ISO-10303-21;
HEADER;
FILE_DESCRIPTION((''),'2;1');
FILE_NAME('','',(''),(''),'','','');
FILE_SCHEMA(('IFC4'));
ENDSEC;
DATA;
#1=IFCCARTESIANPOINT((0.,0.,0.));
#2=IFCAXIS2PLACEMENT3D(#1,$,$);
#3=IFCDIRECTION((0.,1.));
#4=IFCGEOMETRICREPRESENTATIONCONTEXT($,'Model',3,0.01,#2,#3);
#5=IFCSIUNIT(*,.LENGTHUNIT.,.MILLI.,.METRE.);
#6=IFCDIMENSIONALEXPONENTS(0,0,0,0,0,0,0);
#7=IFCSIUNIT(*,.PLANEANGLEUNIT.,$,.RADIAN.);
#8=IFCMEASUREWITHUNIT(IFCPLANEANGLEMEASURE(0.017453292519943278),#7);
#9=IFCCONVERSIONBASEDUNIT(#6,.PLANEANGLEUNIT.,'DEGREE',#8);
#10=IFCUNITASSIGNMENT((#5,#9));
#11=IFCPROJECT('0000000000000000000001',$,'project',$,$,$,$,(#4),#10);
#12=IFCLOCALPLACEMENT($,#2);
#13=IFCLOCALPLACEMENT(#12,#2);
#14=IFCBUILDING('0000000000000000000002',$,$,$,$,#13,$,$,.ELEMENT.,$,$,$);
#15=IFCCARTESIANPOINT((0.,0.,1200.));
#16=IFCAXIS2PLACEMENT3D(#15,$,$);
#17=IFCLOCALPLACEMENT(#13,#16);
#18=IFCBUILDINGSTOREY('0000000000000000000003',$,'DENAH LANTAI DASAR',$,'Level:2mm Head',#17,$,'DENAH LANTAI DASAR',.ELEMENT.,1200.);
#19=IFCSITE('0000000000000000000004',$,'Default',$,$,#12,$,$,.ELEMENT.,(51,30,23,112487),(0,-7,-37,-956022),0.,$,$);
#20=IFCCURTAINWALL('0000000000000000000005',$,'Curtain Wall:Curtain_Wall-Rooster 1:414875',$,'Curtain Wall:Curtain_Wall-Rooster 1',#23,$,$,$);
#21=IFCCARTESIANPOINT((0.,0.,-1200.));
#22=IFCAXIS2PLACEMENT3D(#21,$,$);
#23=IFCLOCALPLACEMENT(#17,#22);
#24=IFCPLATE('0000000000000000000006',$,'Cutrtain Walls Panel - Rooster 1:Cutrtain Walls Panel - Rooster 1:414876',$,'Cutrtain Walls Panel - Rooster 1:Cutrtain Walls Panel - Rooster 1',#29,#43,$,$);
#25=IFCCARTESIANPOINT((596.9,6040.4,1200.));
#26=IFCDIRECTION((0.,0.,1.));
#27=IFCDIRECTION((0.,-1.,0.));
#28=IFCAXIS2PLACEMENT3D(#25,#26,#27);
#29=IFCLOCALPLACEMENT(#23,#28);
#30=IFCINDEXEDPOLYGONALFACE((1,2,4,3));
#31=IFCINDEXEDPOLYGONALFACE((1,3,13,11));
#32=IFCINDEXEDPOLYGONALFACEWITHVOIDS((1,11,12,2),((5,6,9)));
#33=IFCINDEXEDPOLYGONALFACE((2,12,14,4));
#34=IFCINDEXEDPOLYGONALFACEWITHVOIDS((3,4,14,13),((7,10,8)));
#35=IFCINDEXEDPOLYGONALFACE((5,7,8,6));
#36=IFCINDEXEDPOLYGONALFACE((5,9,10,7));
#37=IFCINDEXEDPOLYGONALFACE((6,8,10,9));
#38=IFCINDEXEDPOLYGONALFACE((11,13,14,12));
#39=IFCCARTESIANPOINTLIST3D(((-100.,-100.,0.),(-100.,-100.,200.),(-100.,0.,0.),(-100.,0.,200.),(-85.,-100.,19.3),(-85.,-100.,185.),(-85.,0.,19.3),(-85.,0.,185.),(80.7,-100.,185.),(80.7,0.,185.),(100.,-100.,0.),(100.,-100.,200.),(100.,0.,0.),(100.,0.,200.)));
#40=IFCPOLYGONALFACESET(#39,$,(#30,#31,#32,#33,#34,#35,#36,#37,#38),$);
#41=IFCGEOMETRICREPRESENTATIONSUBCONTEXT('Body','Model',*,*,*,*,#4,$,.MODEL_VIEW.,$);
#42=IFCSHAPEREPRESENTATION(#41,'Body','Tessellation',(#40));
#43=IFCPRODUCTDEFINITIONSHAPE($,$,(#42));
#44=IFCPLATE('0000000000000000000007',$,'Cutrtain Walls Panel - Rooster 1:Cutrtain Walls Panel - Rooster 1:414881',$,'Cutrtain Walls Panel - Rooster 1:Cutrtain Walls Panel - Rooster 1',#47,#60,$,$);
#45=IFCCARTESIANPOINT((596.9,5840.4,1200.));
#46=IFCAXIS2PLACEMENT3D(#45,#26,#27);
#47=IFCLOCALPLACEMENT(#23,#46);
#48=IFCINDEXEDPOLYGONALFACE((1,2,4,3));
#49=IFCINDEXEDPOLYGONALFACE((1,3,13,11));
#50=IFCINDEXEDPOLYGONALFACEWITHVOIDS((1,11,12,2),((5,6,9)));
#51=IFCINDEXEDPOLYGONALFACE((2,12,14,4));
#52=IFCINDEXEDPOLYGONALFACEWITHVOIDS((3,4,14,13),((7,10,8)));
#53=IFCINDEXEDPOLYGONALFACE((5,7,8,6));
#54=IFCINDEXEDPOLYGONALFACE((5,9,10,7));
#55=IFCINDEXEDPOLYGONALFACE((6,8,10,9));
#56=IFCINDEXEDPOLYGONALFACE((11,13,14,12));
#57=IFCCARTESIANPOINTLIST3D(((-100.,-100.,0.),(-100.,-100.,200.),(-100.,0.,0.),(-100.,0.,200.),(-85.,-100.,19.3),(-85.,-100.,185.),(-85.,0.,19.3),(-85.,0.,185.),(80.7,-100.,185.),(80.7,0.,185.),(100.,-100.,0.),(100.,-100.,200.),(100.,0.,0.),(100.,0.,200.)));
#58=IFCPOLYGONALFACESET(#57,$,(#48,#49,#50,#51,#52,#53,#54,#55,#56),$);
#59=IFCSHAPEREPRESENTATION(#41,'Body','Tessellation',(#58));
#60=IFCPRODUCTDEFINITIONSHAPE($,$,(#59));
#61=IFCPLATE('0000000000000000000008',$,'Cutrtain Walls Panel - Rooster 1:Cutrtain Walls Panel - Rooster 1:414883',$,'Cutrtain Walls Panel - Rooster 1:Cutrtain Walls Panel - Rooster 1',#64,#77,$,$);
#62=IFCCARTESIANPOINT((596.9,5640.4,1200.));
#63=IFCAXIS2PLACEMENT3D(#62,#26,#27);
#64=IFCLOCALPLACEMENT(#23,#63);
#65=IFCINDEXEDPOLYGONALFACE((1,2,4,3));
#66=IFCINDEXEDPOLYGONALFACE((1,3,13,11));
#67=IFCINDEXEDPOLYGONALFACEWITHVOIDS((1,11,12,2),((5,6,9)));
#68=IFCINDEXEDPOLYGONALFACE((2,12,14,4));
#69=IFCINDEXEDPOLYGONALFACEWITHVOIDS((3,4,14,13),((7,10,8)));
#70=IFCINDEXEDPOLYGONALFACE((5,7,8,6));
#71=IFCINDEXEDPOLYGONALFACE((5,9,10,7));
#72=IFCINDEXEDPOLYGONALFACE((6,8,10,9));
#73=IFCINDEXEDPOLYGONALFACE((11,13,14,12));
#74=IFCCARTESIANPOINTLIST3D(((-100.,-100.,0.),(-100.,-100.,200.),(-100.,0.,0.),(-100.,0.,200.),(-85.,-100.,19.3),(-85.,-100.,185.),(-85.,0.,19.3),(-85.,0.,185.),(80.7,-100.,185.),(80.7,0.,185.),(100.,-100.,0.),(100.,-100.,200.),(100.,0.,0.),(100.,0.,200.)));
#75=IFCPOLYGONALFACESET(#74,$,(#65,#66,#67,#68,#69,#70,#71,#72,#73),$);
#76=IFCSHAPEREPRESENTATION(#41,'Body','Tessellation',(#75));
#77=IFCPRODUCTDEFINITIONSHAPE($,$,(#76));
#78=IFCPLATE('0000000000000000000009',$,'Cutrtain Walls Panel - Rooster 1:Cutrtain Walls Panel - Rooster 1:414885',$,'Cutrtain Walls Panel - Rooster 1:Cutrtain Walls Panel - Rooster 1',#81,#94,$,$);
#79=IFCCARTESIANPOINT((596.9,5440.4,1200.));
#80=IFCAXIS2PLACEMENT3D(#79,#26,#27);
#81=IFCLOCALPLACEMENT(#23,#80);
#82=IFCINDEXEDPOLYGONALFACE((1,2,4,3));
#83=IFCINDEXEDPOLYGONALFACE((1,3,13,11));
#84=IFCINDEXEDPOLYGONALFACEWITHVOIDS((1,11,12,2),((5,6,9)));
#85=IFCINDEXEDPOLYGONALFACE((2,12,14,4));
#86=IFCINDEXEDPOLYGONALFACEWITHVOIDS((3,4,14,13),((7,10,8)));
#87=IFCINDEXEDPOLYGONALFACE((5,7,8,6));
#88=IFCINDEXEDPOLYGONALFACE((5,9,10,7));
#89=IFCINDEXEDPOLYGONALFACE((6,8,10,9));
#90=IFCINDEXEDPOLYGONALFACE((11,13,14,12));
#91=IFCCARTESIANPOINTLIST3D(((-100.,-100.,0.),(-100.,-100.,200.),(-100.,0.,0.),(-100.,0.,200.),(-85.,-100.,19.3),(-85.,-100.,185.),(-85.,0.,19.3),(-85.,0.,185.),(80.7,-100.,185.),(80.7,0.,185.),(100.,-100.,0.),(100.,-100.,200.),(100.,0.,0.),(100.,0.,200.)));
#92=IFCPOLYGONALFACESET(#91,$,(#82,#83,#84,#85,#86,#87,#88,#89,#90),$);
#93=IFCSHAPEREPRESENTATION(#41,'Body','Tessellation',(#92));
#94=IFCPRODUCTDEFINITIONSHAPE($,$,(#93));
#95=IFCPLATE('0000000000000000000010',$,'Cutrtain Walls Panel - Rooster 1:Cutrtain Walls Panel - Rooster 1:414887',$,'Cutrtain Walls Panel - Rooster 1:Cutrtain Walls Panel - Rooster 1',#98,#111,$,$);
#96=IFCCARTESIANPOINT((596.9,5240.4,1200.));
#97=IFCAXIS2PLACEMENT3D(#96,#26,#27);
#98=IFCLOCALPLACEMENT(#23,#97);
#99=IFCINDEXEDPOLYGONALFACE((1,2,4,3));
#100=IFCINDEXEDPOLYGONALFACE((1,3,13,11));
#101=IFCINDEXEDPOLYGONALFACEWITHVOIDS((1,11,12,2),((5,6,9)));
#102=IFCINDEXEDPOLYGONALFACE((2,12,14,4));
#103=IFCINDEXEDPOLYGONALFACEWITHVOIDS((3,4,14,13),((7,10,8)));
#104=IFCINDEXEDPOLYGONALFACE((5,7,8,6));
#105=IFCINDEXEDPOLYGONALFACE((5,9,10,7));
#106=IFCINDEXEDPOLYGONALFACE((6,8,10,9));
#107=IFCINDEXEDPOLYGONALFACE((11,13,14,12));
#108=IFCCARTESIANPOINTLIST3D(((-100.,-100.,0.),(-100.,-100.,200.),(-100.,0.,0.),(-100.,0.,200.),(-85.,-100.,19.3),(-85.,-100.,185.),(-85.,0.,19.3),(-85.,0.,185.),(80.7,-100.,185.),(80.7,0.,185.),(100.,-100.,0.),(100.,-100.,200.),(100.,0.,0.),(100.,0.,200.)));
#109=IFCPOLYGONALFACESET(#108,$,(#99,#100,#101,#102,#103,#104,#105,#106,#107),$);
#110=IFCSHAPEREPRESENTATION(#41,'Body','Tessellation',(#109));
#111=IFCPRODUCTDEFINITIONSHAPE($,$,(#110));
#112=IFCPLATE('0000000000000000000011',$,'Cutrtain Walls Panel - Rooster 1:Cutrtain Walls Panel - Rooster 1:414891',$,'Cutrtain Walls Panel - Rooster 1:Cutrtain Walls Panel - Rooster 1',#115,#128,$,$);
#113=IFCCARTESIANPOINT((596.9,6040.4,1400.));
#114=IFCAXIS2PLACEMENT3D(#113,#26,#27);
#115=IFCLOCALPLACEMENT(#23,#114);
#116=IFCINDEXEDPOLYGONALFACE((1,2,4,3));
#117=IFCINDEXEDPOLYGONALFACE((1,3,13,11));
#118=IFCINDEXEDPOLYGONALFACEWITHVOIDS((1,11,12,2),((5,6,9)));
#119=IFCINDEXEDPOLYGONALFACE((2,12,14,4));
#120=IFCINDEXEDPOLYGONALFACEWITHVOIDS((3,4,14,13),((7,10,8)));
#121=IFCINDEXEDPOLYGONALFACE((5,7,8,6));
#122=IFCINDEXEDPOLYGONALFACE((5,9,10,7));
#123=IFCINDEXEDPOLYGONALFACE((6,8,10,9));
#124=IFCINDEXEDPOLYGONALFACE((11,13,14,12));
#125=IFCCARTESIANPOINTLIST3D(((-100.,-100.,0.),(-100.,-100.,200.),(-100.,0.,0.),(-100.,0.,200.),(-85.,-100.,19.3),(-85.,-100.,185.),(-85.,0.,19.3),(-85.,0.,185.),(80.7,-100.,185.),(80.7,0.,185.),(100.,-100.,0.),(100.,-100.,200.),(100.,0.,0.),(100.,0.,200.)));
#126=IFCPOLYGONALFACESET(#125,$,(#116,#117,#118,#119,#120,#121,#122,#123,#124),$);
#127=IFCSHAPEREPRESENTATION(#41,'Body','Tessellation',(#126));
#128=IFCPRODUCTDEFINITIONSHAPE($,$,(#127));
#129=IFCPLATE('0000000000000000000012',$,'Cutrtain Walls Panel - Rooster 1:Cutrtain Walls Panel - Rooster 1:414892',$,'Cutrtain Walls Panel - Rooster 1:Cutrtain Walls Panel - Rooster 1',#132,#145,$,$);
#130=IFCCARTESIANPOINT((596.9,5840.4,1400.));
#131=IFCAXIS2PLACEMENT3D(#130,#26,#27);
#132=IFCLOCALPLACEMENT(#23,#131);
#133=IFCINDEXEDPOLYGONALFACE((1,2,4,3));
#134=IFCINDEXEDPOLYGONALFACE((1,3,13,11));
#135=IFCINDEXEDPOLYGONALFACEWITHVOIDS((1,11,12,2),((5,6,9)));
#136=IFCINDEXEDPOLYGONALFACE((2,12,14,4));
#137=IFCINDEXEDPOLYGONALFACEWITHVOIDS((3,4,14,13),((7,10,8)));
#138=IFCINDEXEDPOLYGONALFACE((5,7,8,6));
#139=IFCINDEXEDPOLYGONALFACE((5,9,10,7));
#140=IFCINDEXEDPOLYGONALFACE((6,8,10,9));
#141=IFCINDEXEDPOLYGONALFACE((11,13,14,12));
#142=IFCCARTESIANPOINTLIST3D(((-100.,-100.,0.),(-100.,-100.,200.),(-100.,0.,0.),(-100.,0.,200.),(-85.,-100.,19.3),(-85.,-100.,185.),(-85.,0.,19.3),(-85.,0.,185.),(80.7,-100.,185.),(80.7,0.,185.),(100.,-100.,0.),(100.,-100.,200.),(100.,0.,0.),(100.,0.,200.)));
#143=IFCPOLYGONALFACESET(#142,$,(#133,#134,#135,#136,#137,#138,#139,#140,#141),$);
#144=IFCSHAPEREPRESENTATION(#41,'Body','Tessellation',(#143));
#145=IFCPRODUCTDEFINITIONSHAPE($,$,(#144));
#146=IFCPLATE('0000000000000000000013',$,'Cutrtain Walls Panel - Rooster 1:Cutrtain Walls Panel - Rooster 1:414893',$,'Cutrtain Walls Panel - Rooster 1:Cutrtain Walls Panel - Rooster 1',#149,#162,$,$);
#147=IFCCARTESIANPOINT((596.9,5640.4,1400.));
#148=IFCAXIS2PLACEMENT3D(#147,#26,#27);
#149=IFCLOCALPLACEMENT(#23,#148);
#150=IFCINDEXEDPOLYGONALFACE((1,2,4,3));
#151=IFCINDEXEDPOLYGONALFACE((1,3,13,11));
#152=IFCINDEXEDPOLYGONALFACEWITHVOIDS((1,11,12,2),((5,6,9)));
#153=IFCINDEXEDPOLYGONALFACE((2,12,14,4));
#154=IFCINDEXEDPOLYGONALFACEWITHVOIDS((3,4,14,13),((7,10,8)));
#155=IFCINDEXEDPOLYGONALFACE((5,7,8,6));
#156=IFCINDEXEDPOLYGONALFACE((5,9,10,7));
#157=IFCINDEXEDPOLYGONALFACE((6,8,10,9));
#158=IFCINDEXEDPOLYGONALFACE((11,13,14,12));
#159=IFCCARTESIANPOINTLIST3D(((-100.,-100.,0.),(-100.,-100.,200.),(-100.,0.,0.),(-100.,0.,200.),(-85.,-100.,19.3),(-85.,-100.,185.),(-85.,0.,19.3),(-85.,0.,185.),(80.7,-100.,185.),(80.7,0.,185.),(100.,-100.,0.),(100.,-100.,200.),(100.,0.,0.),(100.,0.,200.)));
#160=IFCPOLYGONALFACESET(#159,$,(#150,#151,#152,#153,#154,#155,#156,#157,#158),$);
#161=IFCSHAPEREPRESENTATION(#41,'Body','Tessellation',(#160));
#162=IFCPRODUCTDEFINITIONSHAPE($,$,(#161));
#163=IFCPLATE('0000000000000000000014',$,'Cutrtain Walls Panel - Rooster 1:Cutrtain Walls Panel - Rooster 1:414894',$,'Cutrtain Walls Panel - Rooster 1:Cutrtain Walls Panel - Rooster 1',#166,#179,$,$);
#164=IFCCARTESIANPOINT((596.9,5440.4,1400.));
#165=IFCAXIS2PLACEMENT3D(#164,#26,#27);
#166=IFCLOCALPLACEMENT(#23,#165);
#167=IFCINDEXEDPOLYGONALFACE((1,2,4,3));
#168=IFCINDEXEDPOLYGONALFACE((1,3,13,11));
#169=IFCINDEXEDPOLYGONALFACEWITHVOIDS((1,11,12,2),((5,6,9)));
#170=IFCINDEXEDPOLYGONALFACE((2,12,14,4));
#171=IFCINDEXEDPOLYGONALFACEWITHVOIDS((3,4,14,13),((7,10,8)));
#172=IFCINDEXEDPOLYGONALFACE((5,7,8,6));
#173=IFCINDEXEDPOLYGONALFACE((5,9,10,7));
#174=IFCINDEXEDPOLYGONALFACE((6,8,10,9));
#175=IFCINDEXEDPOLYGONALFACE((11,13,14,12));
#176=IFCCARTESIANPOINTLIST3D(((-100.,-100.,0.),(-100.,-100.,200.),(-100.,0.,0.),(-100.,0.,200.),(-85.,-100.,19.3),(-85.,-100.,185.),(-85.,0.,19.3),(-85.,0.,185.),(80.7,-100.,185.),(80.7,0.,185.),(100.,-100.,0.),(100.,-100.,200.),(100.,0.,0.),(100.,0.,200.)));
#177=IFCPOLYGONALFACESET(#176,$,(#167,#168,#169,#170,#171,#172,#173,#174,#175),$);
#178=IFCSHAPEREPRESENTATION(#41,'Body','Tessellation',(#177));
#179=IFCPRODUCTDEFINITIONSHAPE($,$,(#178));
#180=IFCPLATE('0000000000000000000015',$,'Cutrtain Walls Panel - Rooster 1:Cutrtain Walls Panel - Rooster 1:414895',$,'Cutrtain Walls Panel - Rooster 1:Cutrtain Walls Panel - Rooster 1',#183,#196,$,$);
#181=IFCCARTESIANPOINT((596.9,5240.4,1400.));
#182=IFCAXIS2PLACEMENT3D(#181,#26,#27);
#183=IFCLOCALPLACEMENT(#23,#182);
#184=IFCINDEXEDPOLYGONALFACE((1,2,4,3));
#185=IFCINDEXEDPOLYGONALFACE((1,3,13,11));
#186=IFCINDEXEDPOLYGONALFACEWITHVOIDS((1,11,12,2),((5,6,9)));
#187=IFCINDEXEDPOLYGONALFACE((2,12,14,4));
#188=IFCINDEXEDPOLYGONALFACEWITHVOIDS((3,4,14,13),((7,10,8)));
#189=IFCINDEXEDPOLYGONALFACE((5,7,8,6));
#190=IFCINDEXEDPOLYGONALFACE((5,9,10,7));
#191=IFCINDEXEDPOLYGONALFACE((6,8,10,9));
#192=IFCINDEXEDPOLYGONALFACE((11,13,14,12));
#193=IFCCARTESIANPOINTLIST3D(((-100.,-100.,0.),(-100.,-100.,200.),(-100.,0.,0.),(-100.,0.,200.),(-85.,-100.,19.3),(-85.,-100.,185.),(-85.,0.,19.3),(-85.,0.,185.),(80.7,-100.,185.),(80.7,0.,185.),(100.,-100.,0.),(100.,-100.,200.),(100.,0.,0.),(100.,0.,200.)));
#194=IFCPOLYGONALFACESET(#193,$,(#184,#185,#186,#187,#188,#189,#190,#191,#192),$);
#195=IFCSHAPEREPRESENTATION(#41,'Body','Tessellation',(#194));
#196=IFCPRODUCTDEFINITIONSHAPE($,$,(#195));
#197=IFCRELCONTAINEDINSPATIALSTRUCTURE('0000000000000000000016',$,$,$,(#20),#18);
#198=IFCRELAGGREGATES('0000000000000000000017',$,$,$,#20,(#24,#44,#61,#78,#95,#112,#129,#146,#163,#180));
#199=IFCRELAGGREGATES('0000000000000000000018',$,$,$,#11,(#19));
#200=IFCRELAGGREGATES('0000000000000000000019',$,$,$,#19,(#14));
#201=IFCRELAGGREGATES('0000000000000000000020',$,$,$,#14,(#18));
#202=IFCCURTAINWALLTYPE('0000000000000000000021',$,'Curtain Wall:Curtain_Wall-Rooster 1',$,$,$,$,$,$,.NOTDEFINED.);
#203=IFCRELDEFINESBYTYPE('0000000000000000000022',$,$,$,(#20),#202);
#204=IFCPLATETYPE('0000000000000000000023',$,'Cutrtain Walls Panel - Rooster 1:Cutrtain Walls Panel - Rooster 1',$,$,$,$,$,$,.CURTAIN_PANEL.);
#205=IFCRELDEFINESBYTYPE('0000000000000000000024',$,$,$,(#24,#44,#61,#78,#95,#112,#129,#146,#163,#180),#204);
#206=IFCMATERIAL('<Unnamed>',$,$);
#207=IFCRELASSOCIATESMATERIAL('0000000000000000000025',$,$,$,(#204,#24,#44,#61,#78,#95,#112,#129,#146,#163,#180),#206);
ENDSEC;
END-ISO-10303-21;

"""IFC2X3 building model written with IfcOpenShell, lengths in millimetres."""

from ifc_helpers import new_model, entity, si_unit, converted_unit, direction, frame, origin, place, context, subcontext, project, spatial, polyline, outline, extrude, source, transform, mapped, material, type_object, type_shapes, element, aggregate, save


model = new_model("IFC2X3")

# Units and contexts
model_context = context("Model", 3, precision=0.01, world=origin(), true_north=direction((0.0, 1.0)))
body_context = subcontext(model_context, "Body", "Model", "MODEL_VIEW")
ifc_project = project(units=[si_unit("LENGTHUNIT", "METRE", prefix="MILLI"), converted_unit("PLANEANGLEUNIT", "DEGREE", entity("IfcPlaneAngleMeasure", 0.017453292519943278), si_unit("PLANEANGLEUNIT", "RADIAN"), dimensions=[0, 0, 0, 0, 0, 0, 0])], contexts=[model_context])

# Site, building, storey
site_placement = place(None, origin())
site = spatial("IfcSite", under=ifc_project, at=site_placement, Name="Default", CompositionType="ELEMENT", RefLatitude=(51, 30, 23, 112487), RefLongitude=(0, -7, -37, -956022), RefElevation=0.0)
building_placement = place(site_placement, origin())
building = spatial("IfcBuilding", under=site, at=building_placement, CompositionType="ELEMENT")
storey_placement = place(building_placement, frame((0.0, 0.0, 1200.0)))
storey = spatial("IfcBuildingStorey", under=building, at=storey_placement, Name="DENAH LANTAI DASAR", ObjectType="Level:2mm Head", LongName="DENAH LANTAI DASAR", CompositionType="ELEMENT", Elevation=1200.0)

# Curtain wall, plates
curtain_wall_type = type_object("IfcCurtainWallType", Name="Curtain Wall:Curtain_Wall-Rooster 1", PredefinedType="NOTDEFINED")
curtain_wall_1_placement = place(storey_placement, frame((0.0, 0.0, -1200.0)))
curtain_wall_1 = element("IfcCurtainWall", 1, at=curtain_wall_1_placement, inside=storey, type_object=curtain_wall_type, Name="Curtain Wall:Curtain_Wall-Rooster 1:414875", ObjectType="Curtain Wall:Curtain_Wall-Rooster 1")
ifc_material_1 = material(Name="<Unnamed>")
plate_type_1 = type_object("IfcPlateType", Name="Cutrtain Walls Panel - Rooster 1:Cutrtain Walls Panel - Rooster 1", PredefinedType="CURTAIN_PANEL", material=ifc_material_1)
shared_shape_1 = source(origin(), body_context, "Body", "SweptSolid", [
    extrude(outline(polyline([(-100.0, -100.0), (100.0, -100.0), (100.0, 100.0), (-100.0, 100.0), (-100.0, -100.0)]), holes=[polyline([(80.7, 85.0), (-85.0, -80.7), (-85.0, 85.0), (80.7, 85.0)])]), frame((0.0, -100.0, 100.0), z_axis=(0.0, 1.0, 0.0), x_axis=(0.0, 0.0, -1.0)), (0.0, 0.0, 1.0), 100.0),
])
type_shapes(plate_type_1, [shared_shape_1])
plate_1_placement = place(curtain_wall_1_placement, frame((596.9, 6040.4, 1200.0), z_axis=(0.0, 0.0, 1.0), x_axis=(0.0, -1.0, 0.0)))
plate_1 = element("IfcPlate", 2, at=plate_1_placement, type_object=plate_type_1, material=ifc_material_1, Name="Cutrtain Walls Panel - Rooster 1:Cutrtain Walls Panel - Rooster 1:414876", ObjectType="Cutrtain Walls Panel - Rooster 1:Cutrtain Walls Panel - Rooster 1", context=body_context, shape_type="MappedRepresentation", body=[
    mapped(shared_shape_1, transform((0.0, 0.0, 0.0), scale=1.0)),
])
plate_2_placement = place(curtain_wall_1_placement, frame((596.9, 5840.4, 1200.0), z_axis=(0.0, 0.0, 1.0), x_axis=(0.0, -1.0, 0.0)))
plate_2 = element("IfcPlate", 3, at=plate_2_placement, type_object=plate_type_1, material=ifc_material_1, Name="Cutrtain Walls Panel - Rooster 1:Cutrtain Walls Panel - Rooster 1:414881", ObjectType="Cutrtain Walls Panel - Rooster 1:Cutrtain Walls Panel - Rooster 1", context=body_context, shape_type="MappedRepresentation", body=[
    mapped(shared_shape_1, transform((0.0, 0.0, 0.0), scale=1.0)),
])
plate_3_placement = place(curtain_wall_1_placement, frame((596.9, 5640.4, 1200.0), z_axis=(0.0, 0.0, 1.0), x_axis=(0.0, -1.0, 0.0)))
plate_3 = element("IfcPlate", 4, at=plate_3_placement, type_object=plate_type_1, material=ifc_material_1, Name="Cutrtain Walls Panel - Rooster 1:Cutrtain Walls Panel - Rooster 1:414883", ObjectType="Cutrtain Walls Panel - Rooster 1:Cutrtain Walls Panel - Rooster 1", context=body_context, shape_type="MappedRepresentation", body=[
    mapped(shared_shape_1, transform((0.0, 0.0, 0.0), scale=1.0)),
])
plate_4_placement = place(curtain_wall_1_placement, frame((596.9, 5440.4, 1200.0), z_axis=(0.0, 0.0, 1.0), x_axis=(0.0, -1.0, 0.0)))
plate_4 = element("IfcPlate", 5, at=plate_4_placement, type_object=plate_type_1, material=ifc_material_1, Name="Cutrtain Walls Panel - Rooster 1:Cutrtain Walls Panel - Rooster 1:414885", ObjectType="Cutrtain Walls Panel - Rooster 1:Cutrtain Walls Panel - Rooster 1", context=body_context, shape_type="MappedRepresentation", body=[
    mapped(shared_shape_1, transform((0.0, 0.0, 0.0), scale=1.0)),
])
plate_5_placement = place(curtain_wall_1_placement, frame((596.9, 5240.4, 1200.0), z_axis=(0.0, 0.0, 1.0), x_axis=(0.0, -1.0, 0.0)))
plate_5 = element("IfcPlate", 6, at=plate_5_placement, type_object=plate_type_1, material=ifc_material_1, Name="Cutrtain Walls Panel - Rooster 1:Cutrtain Walls Panel - Rooster 1:414887", ObjectType="Cutrtain Walls Panel - Rooster 1:Cutrtain Walls Panel - Rooster 1", context=body_context, shape_type="MappedRepresentation", body=[
    mapped(shared_shape_1, transform((0.0, 0.0, 0.0), scale=1.0)),
])
plate_6_placement = place(curtain_wall_1_placement, frame((596.9, 6040.4, 1400.0), z_axis=(0.0, 0.0, 1.0), x_axis=(0.0, -1.0, 0.0)))
plate_6 = element("IfcPlate", 7, at=plate_6_placement, type_object=plate_type_1, material=ifc_material_1, Name="Cutrtain Walls Panel - Rooster 1:Cutrtain Walls Panel - Rooster 1:414891", ObjectType="Cutrtain Walls Panel - Rooster 1:Cutrtain Walls Panel - Rooster 1", context=body_context, shape_type="MappedRepresentation", body=[
    mapped(shared_shape_1, transform((0.0, 0.0, 0.0), scale=1.0)),
])
plate_7_placement = place(curtain_wall_1_placement, frame((596.9, 5840.4, 1400.0), z_axis=(0.0, 0.0, 1.0), x_axis=(0.0, -1.0, 0.0)))
plate_7 = element("IfcPlate", 8, at=plate_7_placement, type_object=plate_type_1, material=ifc_material_1, Name="Cutrtain Walls Panel - Rooster 1:Cutrtain Walls Panel - Rooster 1:414892", ObjectType="Cutrtain Walls Panel - Rooster 1:Cutrtain Walls Panel - Rooster 1", context=body_context, shape_type="MappedRepresentation", body=[
    mapped(shared_shape_1, transform((0.0, 0.0, 0.0), scale=1.0)),
])
plate_8_placement = place(curtain_wall_1_placement, frame((596.9, 5640.4, 1400.0), z_axis=(0.0, 0.0, 1.0), x_axis=(0.0, -1.0, 0.0)))
plate_8 = element("IfcPlate", 9, at=plate_8_placement, type_object=plate_type_1, material=ifc_material_1, Name="Cutrtain Walls Panel - Rooster 1:Cutrtain Walls Panel - Rooster 1:414893", ObjectType="Cutrtain Walls Panel - Rooster 1:Cutrtain Walls Panel - Rooster 1", context=body_context, shape_type="MappedRepresentation", body=[
    mapped(shared_shape_1, transform((0.0, 0.0, 0.0), scale=1.0)),
])
plate_9_placement = place(curtain_wall_1_placement, frame((596.9, 5440.4, 1400.0), z_axis=(0.0, 0.0, 1.0), x_axis=(0.0, -1.0, 0.0)))
plate_9 = element("IfcPlate", 10, at=plate_9_placement, type_object=plate_type_1, material=ifc_material_1, Name="Cutrtain Walls Panel - Rooster 1:Cutrtain Walls Panel - Rooster 1:414894", ObjectType="Cutrtain Walls Panel - Rooster 1:Cutrtain Walls Panel - Rooster 1", context=body_context, shape_type="MappedRepresentation", body=[
    mapped(shared_shape_1, transform((0.0, 0.0, 0.0), scale=1.0)),
])
plate_10_placement = place(curtain_wall_1_placement, frame((596.9, 5240.4, 1400.0), z_axis=(0.0, 0.0, 1.0), x_axis=(0.0, -1.0, 0.0)))
plate_10 = element("IfcPlate", 11, at=plate_10_placement, type_object=plate_type_1, material=ifc_material_1, Name="Cutrtain Walls Panel - Rooster 1:Cutrtain Walls Panel - Rooster 1:414895", ObjectType="Cutrtain Walls Panel - Rooster 1:Cutrtain Walls Panel - Rooster 1", context=body_context, shape_type="MappedRepresentation", body=[
    mapped(shared_shape_1, transform((0.0, 0.0, 0.0), scale=1.0)),
])
aggregate(curtain_wall_1, [plate_1, plate_2, plate_3, plate_4, plate_5, plate_6, plate_7, plate_8, plate_9, plate_10])

save(model, "model.ifc")
